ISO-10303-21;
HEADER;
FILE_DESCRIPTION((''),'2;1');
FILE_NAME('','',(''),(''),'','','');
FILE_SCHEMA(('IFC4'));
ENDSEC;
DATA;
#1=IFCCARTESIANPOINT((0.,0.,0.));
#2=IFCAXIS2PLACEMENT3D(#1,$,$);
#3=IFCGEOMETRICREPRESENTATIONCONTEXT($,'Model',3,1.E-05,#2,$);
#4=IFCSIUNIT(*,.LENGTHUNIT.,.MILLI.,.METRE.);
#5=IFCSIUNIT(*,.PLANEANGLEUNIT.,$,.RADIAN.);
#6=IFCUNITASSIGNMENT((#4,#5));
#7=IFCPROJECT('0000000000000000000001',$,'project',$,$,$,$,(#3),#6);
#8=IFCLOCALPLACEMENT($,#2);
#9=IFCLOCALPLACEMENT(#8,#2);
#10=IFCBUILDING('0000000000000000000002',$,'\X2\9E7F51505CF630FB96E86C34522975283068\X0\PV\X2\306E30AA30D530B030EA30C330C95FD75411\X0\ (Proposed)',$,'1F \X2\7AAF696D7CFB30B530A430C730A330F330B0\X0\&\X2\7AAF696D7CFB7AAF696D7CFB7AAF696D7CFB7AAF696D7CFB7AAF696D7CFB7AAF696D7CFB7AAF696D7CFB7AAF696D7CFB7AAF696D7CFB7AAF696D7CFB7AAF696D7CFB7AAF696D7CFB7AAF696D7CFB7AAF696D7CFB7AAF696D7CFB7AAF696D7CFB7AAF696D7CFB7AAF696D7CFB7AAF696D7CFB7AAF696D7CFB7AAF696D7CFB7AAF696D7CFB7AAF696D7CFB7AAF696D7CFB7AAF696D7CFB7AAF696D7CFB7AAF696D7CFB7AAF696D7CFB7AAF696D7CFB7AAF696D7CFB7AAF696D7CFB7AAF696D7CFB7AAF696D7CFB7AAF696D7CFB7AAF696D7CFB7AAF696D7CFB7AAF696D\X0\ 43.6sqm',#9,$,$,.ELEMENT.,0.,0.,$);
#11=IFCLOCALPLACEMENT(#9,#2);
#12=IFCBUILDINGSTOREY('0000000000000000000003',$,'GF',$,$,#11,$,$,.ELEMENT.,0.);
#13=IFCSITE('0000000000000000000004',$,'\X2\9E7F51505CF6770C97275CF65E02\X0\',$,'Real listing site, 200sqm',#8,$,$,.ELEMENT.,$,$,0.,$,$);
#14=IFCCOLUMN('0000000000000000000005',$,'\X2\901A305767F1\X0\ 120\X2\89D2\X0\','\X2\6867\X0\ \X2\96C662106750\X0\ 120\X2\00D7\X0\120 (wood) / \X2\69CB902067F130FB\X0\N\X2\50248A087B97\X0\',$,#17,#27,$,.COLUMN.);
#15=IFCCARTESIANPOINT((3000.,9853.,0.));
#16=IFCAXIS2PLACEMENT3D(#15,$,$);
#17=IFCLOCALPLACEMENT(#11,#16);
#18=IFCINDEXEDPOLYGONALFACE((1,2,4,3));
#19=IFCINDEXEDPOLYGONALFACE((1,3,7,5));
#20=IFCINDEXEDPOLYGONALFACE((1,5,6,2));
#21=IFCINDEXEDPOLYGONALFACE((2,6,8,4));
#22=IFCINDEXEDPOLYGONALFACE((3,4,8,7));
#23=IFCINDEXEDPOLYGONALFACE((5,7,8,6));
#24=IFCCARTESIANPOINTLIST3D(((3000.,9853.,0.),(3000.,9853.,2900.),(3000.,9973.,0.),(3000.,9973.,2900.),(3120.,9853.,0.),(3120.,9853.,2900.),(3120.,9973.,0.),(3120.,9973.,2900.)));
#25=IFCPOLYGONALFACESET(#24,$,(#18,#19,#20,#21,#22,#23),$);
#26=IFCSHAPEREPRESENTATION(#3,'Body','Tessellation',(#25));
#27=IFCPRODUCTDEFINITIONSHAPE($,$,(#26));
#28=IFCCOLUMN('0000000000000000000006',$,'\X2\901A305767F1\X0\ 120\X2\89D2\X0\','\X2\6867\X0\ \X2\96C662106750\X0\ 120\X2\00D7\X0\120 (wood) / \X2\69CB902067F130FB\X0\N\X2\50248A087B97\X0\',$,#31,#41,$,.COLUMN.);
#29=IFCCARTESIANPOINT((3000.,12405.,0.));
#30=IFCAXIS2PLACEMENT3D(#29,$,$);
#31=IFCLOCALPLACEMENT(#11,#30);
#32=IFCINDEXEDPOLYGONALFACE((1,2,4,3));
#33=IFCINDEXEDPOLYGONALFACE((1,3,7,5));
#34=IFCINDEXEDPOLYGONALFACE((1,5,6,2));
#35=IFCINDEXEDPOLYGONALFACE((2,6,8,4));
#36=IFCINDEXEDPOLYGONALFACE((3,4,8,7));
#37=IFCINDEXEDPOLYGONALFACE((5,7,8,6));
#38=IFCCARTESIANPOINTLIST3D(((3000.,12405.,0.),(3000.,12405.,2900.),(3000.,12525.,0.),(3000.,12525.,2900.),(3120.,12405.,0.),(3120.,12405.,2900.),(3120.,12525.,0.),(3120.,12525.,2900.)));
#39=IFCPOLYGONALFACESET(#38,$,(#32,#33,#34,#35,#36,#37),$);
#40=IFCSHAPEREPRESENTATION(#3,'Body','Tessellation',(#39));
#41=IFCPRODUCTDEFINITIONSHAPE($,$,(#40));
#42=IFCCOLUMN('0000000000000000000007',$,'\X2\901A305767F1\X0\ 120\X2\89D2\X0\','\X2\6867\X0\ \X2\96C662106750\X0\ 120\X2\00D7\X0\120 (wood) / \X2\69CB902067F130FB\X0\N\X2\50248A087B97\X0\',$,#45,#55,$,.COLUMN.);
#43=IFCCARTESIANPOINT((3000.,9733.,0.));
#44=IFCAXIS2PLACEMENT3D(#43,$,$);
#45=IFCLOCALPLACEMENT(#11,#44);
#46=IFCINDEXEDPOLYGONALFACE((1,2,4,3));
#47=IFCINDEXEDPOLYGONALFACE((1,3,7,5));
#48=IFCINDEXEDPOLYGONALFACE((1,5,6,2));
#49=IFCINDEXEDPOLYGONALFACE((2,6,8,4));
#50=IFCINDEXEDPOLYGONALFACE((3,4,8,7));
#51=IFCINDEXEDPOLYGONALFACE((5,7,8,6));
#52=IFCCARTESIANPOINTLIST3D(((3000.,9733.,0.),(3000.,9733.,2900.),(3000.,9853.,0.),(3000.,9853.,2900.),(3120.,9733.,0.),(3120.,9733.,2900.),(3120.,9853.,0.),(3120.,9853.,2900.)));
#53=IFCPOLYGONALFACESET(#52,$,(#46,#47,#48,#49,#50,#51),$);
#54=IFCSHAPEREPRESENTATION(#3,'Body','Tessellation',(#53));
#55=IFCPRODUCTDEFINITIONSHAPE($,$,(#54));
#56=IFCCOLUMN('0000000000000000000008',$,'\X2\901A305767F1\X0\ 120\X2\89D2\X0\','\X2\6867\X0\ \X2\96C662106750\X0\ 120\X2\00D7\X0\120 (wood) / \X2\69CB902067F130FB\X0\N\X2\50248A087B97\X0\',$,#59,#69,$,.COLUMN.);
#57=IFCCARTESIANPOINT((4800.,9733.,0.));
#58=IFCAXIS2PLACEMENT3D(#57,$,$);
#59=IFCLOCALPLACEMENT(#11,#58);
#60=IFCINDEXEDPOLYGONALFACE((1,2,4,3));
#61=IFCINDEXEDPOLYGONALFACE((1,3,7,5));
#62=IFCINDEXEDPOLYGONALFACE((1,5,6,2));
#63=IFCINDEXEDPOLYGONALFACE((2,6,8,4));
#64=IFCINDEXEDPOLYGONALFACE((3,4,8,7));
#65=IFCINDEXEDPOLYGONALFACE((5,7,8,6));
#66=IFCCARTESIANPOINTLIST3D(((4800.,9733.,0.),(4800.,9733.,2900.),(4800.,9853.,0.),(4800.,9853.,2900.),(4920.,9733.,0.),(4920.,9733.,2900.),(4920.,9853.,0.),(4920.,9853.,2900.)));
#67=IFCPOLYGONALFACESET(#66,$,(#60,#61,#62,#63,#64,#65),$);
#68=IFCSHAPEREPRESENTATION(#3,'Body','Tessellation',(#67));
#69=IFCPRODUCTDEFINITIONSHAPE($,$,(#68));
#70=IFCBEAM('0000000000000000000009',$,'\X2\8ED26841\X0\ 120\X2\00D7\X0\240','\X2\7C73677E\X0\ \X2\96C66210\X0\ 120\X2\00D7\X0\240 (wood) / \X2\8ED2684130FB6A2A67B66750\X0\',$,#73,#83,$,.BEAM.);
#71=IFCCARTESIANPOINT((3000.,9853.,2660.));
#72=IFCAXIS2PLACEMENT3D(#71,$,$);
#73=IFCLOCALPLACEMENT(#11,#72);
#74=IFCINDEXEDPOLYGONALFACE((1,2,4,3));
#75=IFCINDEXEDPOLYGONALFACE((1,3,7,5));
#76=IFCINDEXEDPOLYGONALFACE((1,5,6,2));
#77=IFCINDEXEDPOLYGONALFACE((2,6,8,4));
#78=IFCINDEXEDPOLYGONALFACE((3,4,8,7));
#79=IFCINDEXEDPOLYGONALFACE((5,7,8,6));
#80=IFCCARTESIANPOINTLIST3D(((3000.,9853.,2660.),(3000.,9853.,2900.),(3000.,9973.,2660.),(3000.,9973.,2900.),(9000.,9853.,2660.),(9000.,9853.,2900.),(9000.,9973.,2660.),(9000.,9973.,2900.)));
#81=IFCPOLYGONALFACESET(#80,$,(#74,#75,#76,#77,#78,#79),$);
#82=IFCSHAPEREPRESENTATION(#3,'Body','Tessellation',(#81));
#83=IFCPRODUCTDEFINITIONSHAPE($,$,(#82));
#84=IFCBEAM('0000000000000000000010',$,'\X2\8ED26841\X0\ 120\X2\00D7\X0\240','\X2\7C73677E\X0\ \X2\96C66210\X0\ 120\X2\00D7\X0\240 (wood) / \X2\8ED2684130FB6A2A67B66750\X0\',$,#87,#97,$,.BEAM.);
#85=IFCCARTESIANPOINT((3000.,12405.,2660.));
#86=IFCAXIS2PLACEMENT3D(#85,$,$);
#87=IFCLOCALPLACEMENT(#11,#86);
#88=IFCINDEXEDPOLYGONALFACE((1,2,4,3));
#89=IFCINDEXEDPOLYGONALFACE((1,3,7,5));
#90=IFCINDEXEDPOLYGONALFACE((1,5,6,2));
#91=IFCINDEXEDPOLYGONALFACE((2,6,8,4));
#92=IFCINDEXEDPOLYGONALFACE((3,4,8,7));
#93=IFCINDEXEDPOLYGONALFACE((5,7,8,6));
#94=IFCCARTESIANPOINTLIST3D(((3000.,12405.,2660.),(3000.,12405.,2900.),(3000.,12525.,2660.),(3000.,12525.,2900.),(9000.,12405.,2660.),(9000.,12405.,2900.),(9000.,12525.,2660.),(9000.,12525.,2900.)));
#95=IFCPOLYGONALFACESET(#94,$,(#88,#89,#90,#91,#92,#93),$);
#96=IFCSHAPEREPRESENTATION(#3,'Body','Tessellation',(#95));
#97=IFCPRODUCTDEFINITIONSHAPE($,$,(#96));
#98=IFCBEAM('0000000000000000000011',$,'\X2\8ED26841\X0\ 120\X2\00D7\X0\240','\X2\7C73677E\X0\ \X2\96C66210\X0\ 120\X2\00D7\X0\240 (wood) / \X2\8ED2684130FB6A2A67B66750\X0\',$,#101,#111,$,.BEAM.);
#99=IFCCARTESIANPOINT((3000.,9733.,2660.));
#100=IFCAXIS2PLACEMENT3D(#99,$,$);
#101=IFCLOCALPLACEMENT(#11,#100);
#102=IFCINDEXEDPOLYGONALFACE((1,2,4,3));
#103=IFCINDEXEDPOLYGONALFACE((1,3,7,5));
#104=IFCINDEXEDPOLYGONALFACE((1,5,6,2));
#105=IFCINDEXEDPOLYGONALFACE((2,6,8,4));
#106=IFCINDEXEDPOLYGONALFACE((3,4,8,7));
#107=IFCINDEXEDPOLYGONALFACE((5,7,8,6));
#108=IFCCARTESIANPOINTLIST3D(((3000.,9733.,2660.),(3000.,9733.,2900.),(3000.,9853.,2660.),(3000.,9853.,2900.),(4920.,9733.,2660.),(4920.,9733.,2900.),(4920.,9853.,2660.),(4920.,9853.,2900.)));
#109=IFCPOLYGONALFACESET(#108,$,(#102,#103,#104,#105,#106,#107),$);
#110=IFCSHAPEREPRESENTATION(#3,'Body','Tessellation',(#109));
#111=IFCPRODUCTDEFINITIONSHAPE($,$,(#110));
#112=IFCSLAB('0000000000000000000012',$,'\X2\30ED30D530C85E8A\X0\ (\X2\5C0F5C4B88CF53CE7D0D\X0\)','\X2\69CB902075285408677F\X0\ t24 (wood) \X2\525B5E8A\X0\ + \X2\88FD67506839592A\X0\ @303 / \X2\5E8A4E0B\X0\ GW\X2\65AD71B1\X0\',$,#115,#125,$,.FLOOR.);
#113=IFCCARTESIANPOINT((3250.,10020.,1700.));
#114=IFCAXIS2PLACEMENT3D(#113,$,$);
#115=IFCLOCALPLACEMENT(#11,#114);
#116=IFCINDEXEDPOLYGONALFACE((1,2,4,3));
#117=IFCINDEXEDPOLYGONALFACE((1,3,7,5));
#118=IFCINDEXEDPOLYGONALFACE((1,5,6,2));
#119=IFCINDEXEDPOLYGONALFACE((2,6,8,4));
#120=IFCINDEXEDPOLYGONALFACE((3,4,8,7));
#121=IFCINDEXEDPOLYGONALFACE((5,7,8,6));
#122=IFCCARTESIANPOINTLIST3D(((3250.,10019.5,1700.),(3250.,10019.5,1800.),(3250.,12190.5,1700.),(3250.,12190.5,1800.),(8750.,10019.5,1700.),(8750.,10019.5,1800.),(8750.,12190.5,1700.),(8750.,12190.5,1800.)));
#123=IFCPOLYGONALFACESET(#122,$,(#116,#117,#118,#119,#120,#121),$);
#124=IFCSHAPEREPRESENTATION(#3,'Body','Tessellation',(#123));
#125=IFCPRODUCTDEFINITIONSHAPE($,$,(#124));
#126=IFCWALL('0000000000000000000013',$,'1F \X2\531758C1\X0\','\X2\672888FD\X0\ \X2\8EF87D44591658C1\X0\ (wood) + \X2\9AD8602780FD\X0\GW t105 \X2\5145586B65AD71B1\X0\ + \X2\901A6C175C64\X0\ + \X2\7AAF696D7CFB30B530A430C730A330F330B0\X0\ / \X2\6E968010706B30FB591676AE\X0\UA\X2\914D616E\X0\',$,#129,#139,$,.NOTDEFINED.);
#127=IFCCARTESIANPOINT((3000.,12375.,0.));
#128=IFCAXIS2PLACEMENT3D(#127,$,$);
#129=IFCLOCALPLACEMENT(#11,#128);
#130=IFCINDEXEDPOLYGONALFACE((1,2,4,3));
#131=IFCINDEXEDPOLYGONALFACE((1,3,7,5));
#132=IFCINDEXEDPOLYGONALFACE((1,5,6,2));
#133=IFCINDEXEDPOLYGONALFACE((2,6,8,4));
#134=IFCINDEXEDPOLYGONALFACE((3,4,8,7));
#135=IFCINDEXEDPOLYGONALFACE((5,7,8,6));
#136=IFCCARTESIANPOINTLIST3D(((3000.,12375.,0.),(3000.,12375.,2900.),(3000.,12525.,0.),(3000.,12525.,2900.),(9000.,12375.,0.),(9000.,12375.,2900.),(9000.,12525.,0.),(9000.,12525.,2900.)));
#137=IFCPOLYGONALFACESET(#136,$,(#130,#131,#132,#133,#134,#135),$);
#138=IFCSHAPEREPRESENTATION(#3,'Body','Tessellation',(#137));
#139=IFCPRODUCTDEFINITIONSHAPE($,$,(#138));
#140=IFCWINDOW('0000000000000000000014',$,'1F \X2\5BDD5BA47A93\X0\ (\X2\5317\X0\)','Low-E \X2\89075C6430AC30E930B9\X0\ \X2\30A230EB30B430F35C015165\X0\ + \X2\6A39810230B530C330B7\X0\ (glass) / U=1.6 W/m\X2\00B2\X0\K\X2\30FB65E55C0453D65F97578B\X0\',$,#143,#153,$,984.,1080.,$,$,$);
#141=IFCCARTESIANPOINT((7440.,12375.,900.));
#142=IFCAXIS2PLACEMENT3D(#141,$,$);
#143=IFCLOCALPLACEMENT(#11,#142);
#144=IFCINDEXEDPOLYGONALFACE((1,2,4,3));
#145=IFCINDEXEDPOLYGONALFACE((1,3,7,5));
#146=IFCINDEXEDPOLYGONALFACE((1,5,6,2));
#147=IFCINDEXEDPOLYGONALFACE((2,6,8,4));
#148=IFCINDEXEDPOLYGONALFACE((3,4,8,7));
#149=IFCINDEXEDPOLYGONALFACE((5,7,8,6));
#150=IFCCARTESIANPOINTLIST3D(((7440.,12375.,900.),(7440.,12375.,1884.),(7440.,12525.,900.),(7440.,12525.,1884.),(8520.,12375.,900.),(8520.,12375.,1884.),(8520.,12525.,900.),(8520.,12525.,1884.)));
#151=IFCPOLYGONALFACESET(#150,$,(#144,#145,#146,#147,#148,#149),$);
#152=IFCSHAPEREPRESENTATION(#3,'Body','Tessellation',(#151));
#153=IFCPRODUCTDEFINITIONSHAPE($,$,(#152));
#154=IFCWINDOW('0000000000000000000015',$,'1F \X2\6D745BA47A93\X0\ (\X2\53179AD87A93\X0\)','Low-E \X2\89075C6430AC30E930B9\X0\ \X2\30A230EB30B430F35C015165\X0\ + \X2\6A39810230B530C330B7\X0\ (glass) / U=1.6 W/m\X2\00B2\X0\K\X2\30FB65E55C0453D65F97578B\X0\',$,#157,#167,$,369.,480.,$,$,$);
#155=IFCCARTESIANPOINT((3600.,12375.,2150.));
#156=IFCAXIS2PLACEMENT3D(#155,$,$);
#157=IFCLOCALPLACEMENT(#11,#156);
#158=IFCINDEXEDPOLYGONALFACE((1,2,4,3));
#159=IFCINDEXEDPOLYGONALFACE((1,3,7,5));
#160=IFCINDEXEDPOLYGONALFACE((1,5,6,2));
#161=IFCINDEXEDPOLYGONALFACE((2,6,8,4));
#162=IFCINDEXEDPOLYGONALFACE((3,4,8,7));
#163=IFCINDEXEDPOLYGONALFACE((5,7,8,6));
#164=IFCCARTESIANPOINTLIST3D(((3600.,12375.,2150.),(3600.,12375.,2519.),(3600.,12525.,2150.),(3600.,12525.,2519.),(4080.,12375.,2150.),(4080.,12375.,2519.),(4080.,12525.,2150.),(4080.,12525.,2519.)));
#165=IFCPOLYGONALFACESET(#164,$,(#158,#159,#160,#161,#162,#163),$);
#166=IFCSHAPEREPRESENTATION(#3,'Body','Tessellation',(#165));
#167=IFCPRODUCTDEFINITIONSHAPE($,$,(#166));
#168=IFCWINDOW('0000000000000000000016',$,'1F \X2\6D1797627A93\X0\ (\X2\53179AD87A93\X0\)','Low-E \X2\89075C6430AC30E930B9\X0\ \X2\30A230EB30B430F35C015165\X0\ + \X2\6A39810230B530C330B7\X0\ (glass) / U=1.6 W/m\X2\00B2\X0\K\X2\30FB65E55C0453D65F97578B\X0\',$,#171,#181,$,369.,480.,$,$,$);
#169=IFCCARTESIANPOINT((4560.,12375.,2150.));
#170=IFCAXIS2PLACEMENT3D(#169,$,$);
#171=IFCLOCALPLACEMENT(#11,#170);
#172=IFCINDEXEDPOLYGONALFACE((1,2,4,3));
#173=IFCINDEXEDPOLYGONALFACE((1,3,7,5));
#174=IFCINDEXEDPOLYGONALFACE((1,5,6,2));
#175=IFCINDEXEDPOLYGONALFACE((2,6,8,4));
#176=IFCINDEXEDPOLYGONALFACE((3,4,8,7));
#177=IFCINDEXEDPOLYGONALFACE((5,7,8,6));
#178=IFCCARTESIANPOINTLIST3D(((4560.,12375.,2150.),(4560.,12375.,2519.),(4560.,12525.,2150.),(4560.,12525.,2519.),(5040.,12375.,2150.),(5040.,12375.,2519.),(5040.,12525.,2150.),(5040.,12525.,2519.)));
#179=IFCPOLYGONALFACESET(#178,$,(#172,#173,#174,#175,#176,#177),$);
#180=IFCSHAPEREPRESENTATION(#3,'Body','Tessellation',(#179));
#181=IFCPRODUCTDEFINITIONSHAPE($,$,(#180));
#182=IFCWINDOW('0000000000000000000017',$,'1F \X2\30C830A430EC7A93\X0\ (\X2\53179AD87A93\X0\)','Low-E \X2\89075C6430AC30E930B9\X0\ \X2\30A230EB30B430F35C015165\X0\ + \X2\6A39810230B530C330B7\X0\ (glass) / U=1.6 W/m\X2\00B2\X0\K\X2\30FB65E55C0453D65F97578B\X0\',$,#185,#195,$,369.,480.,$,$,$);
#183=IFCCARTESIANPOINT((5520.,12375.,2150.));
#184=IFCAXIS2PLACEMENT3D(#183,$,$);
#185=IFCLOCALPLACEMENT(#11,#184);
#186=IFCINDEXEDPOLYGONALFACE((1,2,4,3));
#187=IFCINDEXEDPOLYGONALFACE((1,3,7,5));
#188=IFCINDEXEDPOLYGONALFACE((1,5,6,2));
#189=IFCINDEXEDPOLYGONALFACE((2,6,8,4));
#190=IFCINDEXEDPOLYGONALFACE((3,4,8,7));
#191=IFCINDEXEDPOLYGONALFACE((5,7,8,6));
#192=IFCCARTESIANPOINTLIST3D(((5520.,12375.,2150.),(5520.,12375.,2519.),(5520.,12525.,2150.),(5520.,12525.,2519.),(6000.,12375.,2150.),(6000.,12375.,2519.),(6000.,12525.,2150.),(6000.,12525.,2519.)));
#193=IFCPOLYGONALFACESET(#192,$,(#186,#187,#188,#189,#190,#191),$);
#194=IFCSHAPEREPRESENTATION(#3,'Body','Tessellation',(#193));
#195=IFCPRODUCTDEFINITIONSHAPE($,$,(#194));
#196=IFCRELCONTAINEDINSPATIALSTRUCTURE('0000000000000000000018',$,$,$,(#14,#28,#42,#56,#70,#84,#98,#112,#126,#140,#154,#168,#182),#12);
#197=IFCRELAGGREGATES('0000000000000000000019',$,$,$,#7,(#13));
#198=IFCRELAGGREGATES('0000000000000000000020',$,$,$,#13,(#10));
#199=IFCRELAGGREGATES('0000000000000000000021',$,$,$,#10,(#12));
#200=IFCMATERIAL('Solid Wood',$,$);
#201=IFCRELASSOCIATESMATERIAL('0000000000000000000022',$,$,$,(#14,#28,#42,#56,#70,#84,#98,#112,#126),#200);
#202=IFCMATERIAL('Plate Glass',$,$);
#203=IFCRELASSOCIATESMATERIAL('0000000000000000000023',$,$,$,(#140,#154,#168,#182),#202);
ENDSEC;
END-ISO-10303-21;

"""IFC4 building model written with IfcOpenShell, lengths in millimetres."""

from ifc_helpers import new_model, si_unit, frame, frame_2d, origin, place, context, project, spatial, rectangle, extrude, material, element, fill, save


model = new_model("IFC4")

# Units and contexts
model_context = context("Model", 3, precision=1e-05, world=origin())
ifc_project = project(units=[si_unit("LENGTHUNIT", "METRE", prefix="MILLI"), si_unit("PLANEANGLEUNIT", "RADIAN")], contexts=[model_context])

# Site, building, storey
site_placement = place(None, origin())
site = spatial("IfcSite", under=ifc_project, at=site_placement, Name="鹿児島県霧島市", ObjectType="Real listing site, 200sqm", CompositionType="ELEMENT", RefElevation=0.0)
building_placement = place(site_placement, origin())
building = spatial("IfcBuilding", under=site, at=building_placement, Name="鹿児島・雨水利用とPVのオフグリッド志向 (Proposed)", ObjectType="1F 窯業系サイディング&窯業系窯業系窯業系窯業系窯業系窯業系窯業系窯業系窯業系窯業系窯業系窯業系窯業系窯業系窯業系窯業系窯業系窯業系窯業系窯業系窯業系窯業系窯業系窯業系窯業系窯業系窯業系窯業系窯業系窯業系窯業系窯業系窯業系窯業系窯業系窯業系窯業 43.6sqm", CompositionType="ELEMENT", ElevationOfRefHeight=0.0, ElevationOfTerrain=0.0)
storey_placement = place(building_placement, origin())
storey = spatial("IfcBuildingStorey", under=building, at=storey_placement, Name="GF", CompositionType="ELEMENT", Elevation=0.0)

# Columns
ifc_material_1 = material(Name="Solid Wood")
column_1_placement = place(storey_placement, frame((3000.0, 9853.0, 0.0)))
element("IfcColumn", 1, at=column_1_placement, inside=storey, material=ifc_material_1, Name="通し柱 120角", Description="桧 集成材 120×120 (wood) / 構造柱・N値計算", PredefinedType="COLUMN", context=model_context, shape_type="SweptSolid", body=[
    extrude(rectangle(XDim=120.0, YDim=120.0, at=frame_2d((60.0, 60.0))), frame((3000.0, 9853.0, 0.0)), (0.0, 0.0, 1.0), 2900.0),
])
column_2_placement = place(storey_placement, frame((3000.0, 12405.0, 0.0)))
element("IfcColumn", 2, at=column_2_placement, inside=storey, material=ifc_material_1, Name="通し柱 120角", Description="桧 集成材 120×120 (wood) / 構造柱・N値計算", PredefinedType="COLUMN", context=model_context, shape_type="SweptSolid", body=[
    extrude(rectangle(XDim=120.0, YDim=120.0, at=frame_2d((60.0, 60.0))), frame((3000.0, 12405.0, 0.0)), (0.0, 0.0, 1.0), 2900.0),
])
column_3_placement = place(storey_placement, frame((3000.0, 9733.0, 0.0)))
element("IfcColumn", 3, at=column_3_placement, inside=storey, material=ifc_material_1, Name="通し柱 120角", Description="桧 集成材 120×120 (wood) / 構造柱・N値計算", PredefinedType="COLUMN", context=model_context, shape_type="SweptSolid", body=[
    extrude(rectangle(XDim=120.0, YDim=120.0, at=frame_2d((60.0, 60.0))), frame((3000.0, 9733.0, 0.0)), (0.0, 0.0, 1.0), 2900.0),
])
column_4_placement = place(storey_placement, frame((4800.0, 9733.0, 0.0)))
element("IfcColumn", 4, at=column_4_placement, inside=storey, material=ifc_material_1, Name="通し柱 120角", Description="桧 集成材 120×120 (wood) / 構造柱・N値計算", PredefinedType="COLUMN", context=model_context, shape_type="SweptSolid", body=[
    extrude(rectangle(XDim=120.0, YDim=120.0, at=frame_2d((60.0, 60.0))), frame((4800.0, 9733.0, 0.0)), (0.0, 0.0, 1.0), 2900.0),
])

# Beams
beam_1_placement = place(storey_placement, frame((3000.0, 9853.0, 2660.0)))
element("IfcBeam", 5, at=beam_1_placement, inside=storey, material=ifc_material_1, Name="軒桁 120×240", Description="米松 集成 120×240 (wood) / 軒桁・横架材", PredefinedType="BEAM", context=model_context, shape_type="SweptSolid", body=[
    extrude(rectangle(XDim=6000.0, YDim=120.0, at=frame_2d((3000.0, 60.0))), frame((3000.0, 9853.0, 2660.0)), (0.0, 0.0, 1.0), 240.0),
])
beam_2_placement = place(storey_placement, frame((3000.0, 12405.0, 2660.0)))
element("IfcBeam", 6, at=beam_2_placement, inside=storey, material=ifc_material_1, Name="軒桁 120×240", Description="米松 集成 120×240 (wood) / 軒桁・横架材", PredefinedType="BEAM", context=model_context, shape_type="SweptSolid", body=[
    extrude(rectangle(XDim=6000.0, YDim=120.0, at=frame_2d((3000.0, 60.0))), frame((3000.0, 12405.0, 2660.0)), (0.0, 0.0, 1.0), 240.0),
])
beam_3_placement = place(storey_placement, frame((3000.0, 9733.0, 2660.0)))
element("IfcBeam", 7, at=beam_3_placement, inside=storey, material=ifc_material_1, Name="軒桁 120×240", Description="米松 集成 120×240 (wood) / 軒桁・横架材", PredefinedType="BEAM", context=model_context, shape_type="SweptSolid", body=[
    extrude(rectangle(XDim=1920.0, YDim=120.0, at=frame_2d((960.0, 60.0))), frame((3000.0, 9733.0, 2660.0)), (0.0, 0.0, 1.0), 240.0),
])

# Slab
slab_1_placement = place(storey_placement, frame((3250.0, 10020.0, 1700.0)))
element("IfcSlab", 8, at=slab_1_placement, inside=storey, material=ifc_material_1, Name="ロフト床 (小屋裏収納)", Description="構造用合板 t24 (wood) 剛床 + 製材根太 @303 / 床下 GW断熱", PredefinedType="FLOOR", context=model_context, shape_type="SweptSolid", body=[
    extrude(rectangle(XDim=5500.0, YDim=2171.0, at=frame_2d((2750.0, 1085.0))), frame((3250.0, 10020.0, 1700.0)), (0.0, 0.0, 1.0), 100.0),
])

# Wall, openings, windows
wall_1_placement = place(storey_placement, frame((3000.0, 12375.0, 0.0)))
wall_1 = element("IfcWall", 9, at=wall_1_placement, inside=storey, material=ifc_material_1, Name="1F 北壁", Description="木製 軸組外壁 (wood) + 高性能GW t105 充填断熱 + 通気層 + 窯業系サイディング / 準耐火・外皮UA配慮", PredefinedType="NOTDEFINED", context=model_context, shape_type="SweptSolid", body=[
    extrude(rectangle(XDim=6000.0, YDim=150.0, at=frame_2d((3000.0, 75.0))), frame((3000.0, 12375.0, 0.0)), (0.0, 0.0, 1.0), 2900.0),
])
opening_1_placement = place(storey_placement, frame((7440.0, 12375.0, 900.0)))
opening_1 = element("IfcOpeningElement", 10, at=opening_1_placement, cuts=wall_1, PredefinedType="NOTDEFINED", context=model_context, shape_type="SweptSolid", body=[
    extrude(rectangle(XDim=1080.0, YDim=150.0, at=frame_2d((540.0, 75.0))), frame((7440.0, 12375.0, 900.0)), (0.0, 0.0, 1.0), 984.0),
])
opening_2_placement = place(storey_placement, frame((3600.0, 12375.0, 2150.0)))
opening_2 = element("IfcOpeningElement", 11, at=opening_2_placement, cuts=wall_1, PredefinedType="NOTDEFINED", context=model_context, shape_type="SweptSolid", body=[
    extrude(rectangle(XDim=480.0, YDim=150.0, at=frame_2d((240.0, 75.0))), frame((3600.0, 12375.0, 2150.0)), (0.0, 0.0, 1.0), 369.0),
])
opening_3_placement = place(storey_placement, frame((4560.0, 12375.0, 2150.0)))
opening_3 = element("IfcOpeningElement", 12, at=opening_3_placement, cuts=wall_1, PredefinedType="NOTDEFINED", context=model_context, shape_type="SweptSolid", body=[
    extrude(rectangle(XDim=480.0, YDim=150.0, at=frame_2d((240.0, 75.0))), frame((4560.0, 12375.0, 2150.0)), (0.0, 0.0, 1.0), 369.0),
])
opening_4_placement = place(storey_placement, frame((5520.0, 12375.0, 2150.0)))
opening_4 = element("IfcOpeningElement", 13, at=opening_4_placement, cuts=wall_1, PredefinedType="NOTDEFINED", context=model_context, shape_type="SweptSolid", body=[
    extrude(rectangle(XDim=480.0, YDim=150.0, at=frame_2d((240.0, 75.0))), frame((5520.0, 12375.0, 2150.0)), (0.0, 0.0, 1.0), 369.0),
])
ifc_material_2 = material(Name="Plate Glass")
window_1_placement = place(storey_placement, frame((7440.0, 12375.0, 900.0)))
window_1 = element("IfcWindow", 14, at=window_1_placement, inside=storey, material=ifc_material_2, Name="1F 寝室窓 (北)", Description="Low-E 複層ガラス アルゴン封入 + 樹脂サッシ (glass) / U=1.6 W/m²K・日射取得型", OverallHeight=984.0, OverallWidth=1080.0, context=model_context, shape_type="SweptSolid", body=[
    extrude(rectangle(XDim=1080.0, YDim=150.0, at=frame_2d((540.0, 75.0))), frame((7440.0, 12375.0, 900.0)), (0.0, 0.0, 1.0), 984.0),
])
fill(opening_1, window_1)
window_2_placement = place(storey_placement, frame((3600.0, 12375.0, 2150.0)))
window_2 = element("IfcWindow", 15, at=window_2_placement, inside=storey, material=ifc_material_2, Name="1F 浴室窓 (北高窓)", Description="Low-E 複層ガラス アルゴン封入 + 樹脂サッシ (glass) / U=1.6 W/m²K・日射取得型", OverallHeight=369.0, OverallWidth=480.0, context=model_context, shape_type="SweptSolid", body=[
    extrude(rectangle(XDim=480.0, YDim=150.0, at=frame_2d((240.0, 75.0))), frame((3600.0, 12375.0, 2150.0)), (0.0, 0.0, 1.0), 369.0),
])
fill(opening_2, window_2)
window_3_placement = place(storey_placement, frame((4560.0, 12375.0, 2150.0)))
window_3 = element("IfcWindow", 16, at=window_3_placement, inside=storey, material=ifc_material_2, Name="1F 洗面窓 (北高窓)", Description="Low-E 複層ガラス アルゴン封入 + 樹脂サッシ (glass) / U=1.6 W/m²K・日射取得型", OverallHeight=369.0, OverallWidth=480.0, context=model_context, shape_type="SweptSolid", body=[
    extrude(rectangle(XDim=480.0, YDim=150.0, at=frame_2d((240.0, 75.0))), frame((4560.0, 12375.0, 2150.0)), (0.0, 0.0, 1.0), 369.0),
])
fill(opening_3, window_3)
window_4_placement = place(storey_placement, frame((5520.0, 12375.0, 2150.0)))
window_4 = element("IfcWindow", 17, at=window_4_placement, inside=storey, material=ifc_material_2, Name="1F トイレ窓 (北高窓)", Description="Low-E 複層ガラス アルゴン封入 + 樹脂サッシ (glass) / U=1.6 W/m²K・日射取得型", OverallHeight=369.0, OverallWidth=480.0, context=model_context, shape_type="SweptSolid", body=[
    extrude(rectangle(XDim=480.0, YDim=150.0, at=frame_2d((240.0, 75.0))), frame((5520.0, 12375.0, 2150.0)), (0.0, 0.0, 1.0), 369.0),
])
fill(opening_4, window_4)

save(model, "model.ifc")
